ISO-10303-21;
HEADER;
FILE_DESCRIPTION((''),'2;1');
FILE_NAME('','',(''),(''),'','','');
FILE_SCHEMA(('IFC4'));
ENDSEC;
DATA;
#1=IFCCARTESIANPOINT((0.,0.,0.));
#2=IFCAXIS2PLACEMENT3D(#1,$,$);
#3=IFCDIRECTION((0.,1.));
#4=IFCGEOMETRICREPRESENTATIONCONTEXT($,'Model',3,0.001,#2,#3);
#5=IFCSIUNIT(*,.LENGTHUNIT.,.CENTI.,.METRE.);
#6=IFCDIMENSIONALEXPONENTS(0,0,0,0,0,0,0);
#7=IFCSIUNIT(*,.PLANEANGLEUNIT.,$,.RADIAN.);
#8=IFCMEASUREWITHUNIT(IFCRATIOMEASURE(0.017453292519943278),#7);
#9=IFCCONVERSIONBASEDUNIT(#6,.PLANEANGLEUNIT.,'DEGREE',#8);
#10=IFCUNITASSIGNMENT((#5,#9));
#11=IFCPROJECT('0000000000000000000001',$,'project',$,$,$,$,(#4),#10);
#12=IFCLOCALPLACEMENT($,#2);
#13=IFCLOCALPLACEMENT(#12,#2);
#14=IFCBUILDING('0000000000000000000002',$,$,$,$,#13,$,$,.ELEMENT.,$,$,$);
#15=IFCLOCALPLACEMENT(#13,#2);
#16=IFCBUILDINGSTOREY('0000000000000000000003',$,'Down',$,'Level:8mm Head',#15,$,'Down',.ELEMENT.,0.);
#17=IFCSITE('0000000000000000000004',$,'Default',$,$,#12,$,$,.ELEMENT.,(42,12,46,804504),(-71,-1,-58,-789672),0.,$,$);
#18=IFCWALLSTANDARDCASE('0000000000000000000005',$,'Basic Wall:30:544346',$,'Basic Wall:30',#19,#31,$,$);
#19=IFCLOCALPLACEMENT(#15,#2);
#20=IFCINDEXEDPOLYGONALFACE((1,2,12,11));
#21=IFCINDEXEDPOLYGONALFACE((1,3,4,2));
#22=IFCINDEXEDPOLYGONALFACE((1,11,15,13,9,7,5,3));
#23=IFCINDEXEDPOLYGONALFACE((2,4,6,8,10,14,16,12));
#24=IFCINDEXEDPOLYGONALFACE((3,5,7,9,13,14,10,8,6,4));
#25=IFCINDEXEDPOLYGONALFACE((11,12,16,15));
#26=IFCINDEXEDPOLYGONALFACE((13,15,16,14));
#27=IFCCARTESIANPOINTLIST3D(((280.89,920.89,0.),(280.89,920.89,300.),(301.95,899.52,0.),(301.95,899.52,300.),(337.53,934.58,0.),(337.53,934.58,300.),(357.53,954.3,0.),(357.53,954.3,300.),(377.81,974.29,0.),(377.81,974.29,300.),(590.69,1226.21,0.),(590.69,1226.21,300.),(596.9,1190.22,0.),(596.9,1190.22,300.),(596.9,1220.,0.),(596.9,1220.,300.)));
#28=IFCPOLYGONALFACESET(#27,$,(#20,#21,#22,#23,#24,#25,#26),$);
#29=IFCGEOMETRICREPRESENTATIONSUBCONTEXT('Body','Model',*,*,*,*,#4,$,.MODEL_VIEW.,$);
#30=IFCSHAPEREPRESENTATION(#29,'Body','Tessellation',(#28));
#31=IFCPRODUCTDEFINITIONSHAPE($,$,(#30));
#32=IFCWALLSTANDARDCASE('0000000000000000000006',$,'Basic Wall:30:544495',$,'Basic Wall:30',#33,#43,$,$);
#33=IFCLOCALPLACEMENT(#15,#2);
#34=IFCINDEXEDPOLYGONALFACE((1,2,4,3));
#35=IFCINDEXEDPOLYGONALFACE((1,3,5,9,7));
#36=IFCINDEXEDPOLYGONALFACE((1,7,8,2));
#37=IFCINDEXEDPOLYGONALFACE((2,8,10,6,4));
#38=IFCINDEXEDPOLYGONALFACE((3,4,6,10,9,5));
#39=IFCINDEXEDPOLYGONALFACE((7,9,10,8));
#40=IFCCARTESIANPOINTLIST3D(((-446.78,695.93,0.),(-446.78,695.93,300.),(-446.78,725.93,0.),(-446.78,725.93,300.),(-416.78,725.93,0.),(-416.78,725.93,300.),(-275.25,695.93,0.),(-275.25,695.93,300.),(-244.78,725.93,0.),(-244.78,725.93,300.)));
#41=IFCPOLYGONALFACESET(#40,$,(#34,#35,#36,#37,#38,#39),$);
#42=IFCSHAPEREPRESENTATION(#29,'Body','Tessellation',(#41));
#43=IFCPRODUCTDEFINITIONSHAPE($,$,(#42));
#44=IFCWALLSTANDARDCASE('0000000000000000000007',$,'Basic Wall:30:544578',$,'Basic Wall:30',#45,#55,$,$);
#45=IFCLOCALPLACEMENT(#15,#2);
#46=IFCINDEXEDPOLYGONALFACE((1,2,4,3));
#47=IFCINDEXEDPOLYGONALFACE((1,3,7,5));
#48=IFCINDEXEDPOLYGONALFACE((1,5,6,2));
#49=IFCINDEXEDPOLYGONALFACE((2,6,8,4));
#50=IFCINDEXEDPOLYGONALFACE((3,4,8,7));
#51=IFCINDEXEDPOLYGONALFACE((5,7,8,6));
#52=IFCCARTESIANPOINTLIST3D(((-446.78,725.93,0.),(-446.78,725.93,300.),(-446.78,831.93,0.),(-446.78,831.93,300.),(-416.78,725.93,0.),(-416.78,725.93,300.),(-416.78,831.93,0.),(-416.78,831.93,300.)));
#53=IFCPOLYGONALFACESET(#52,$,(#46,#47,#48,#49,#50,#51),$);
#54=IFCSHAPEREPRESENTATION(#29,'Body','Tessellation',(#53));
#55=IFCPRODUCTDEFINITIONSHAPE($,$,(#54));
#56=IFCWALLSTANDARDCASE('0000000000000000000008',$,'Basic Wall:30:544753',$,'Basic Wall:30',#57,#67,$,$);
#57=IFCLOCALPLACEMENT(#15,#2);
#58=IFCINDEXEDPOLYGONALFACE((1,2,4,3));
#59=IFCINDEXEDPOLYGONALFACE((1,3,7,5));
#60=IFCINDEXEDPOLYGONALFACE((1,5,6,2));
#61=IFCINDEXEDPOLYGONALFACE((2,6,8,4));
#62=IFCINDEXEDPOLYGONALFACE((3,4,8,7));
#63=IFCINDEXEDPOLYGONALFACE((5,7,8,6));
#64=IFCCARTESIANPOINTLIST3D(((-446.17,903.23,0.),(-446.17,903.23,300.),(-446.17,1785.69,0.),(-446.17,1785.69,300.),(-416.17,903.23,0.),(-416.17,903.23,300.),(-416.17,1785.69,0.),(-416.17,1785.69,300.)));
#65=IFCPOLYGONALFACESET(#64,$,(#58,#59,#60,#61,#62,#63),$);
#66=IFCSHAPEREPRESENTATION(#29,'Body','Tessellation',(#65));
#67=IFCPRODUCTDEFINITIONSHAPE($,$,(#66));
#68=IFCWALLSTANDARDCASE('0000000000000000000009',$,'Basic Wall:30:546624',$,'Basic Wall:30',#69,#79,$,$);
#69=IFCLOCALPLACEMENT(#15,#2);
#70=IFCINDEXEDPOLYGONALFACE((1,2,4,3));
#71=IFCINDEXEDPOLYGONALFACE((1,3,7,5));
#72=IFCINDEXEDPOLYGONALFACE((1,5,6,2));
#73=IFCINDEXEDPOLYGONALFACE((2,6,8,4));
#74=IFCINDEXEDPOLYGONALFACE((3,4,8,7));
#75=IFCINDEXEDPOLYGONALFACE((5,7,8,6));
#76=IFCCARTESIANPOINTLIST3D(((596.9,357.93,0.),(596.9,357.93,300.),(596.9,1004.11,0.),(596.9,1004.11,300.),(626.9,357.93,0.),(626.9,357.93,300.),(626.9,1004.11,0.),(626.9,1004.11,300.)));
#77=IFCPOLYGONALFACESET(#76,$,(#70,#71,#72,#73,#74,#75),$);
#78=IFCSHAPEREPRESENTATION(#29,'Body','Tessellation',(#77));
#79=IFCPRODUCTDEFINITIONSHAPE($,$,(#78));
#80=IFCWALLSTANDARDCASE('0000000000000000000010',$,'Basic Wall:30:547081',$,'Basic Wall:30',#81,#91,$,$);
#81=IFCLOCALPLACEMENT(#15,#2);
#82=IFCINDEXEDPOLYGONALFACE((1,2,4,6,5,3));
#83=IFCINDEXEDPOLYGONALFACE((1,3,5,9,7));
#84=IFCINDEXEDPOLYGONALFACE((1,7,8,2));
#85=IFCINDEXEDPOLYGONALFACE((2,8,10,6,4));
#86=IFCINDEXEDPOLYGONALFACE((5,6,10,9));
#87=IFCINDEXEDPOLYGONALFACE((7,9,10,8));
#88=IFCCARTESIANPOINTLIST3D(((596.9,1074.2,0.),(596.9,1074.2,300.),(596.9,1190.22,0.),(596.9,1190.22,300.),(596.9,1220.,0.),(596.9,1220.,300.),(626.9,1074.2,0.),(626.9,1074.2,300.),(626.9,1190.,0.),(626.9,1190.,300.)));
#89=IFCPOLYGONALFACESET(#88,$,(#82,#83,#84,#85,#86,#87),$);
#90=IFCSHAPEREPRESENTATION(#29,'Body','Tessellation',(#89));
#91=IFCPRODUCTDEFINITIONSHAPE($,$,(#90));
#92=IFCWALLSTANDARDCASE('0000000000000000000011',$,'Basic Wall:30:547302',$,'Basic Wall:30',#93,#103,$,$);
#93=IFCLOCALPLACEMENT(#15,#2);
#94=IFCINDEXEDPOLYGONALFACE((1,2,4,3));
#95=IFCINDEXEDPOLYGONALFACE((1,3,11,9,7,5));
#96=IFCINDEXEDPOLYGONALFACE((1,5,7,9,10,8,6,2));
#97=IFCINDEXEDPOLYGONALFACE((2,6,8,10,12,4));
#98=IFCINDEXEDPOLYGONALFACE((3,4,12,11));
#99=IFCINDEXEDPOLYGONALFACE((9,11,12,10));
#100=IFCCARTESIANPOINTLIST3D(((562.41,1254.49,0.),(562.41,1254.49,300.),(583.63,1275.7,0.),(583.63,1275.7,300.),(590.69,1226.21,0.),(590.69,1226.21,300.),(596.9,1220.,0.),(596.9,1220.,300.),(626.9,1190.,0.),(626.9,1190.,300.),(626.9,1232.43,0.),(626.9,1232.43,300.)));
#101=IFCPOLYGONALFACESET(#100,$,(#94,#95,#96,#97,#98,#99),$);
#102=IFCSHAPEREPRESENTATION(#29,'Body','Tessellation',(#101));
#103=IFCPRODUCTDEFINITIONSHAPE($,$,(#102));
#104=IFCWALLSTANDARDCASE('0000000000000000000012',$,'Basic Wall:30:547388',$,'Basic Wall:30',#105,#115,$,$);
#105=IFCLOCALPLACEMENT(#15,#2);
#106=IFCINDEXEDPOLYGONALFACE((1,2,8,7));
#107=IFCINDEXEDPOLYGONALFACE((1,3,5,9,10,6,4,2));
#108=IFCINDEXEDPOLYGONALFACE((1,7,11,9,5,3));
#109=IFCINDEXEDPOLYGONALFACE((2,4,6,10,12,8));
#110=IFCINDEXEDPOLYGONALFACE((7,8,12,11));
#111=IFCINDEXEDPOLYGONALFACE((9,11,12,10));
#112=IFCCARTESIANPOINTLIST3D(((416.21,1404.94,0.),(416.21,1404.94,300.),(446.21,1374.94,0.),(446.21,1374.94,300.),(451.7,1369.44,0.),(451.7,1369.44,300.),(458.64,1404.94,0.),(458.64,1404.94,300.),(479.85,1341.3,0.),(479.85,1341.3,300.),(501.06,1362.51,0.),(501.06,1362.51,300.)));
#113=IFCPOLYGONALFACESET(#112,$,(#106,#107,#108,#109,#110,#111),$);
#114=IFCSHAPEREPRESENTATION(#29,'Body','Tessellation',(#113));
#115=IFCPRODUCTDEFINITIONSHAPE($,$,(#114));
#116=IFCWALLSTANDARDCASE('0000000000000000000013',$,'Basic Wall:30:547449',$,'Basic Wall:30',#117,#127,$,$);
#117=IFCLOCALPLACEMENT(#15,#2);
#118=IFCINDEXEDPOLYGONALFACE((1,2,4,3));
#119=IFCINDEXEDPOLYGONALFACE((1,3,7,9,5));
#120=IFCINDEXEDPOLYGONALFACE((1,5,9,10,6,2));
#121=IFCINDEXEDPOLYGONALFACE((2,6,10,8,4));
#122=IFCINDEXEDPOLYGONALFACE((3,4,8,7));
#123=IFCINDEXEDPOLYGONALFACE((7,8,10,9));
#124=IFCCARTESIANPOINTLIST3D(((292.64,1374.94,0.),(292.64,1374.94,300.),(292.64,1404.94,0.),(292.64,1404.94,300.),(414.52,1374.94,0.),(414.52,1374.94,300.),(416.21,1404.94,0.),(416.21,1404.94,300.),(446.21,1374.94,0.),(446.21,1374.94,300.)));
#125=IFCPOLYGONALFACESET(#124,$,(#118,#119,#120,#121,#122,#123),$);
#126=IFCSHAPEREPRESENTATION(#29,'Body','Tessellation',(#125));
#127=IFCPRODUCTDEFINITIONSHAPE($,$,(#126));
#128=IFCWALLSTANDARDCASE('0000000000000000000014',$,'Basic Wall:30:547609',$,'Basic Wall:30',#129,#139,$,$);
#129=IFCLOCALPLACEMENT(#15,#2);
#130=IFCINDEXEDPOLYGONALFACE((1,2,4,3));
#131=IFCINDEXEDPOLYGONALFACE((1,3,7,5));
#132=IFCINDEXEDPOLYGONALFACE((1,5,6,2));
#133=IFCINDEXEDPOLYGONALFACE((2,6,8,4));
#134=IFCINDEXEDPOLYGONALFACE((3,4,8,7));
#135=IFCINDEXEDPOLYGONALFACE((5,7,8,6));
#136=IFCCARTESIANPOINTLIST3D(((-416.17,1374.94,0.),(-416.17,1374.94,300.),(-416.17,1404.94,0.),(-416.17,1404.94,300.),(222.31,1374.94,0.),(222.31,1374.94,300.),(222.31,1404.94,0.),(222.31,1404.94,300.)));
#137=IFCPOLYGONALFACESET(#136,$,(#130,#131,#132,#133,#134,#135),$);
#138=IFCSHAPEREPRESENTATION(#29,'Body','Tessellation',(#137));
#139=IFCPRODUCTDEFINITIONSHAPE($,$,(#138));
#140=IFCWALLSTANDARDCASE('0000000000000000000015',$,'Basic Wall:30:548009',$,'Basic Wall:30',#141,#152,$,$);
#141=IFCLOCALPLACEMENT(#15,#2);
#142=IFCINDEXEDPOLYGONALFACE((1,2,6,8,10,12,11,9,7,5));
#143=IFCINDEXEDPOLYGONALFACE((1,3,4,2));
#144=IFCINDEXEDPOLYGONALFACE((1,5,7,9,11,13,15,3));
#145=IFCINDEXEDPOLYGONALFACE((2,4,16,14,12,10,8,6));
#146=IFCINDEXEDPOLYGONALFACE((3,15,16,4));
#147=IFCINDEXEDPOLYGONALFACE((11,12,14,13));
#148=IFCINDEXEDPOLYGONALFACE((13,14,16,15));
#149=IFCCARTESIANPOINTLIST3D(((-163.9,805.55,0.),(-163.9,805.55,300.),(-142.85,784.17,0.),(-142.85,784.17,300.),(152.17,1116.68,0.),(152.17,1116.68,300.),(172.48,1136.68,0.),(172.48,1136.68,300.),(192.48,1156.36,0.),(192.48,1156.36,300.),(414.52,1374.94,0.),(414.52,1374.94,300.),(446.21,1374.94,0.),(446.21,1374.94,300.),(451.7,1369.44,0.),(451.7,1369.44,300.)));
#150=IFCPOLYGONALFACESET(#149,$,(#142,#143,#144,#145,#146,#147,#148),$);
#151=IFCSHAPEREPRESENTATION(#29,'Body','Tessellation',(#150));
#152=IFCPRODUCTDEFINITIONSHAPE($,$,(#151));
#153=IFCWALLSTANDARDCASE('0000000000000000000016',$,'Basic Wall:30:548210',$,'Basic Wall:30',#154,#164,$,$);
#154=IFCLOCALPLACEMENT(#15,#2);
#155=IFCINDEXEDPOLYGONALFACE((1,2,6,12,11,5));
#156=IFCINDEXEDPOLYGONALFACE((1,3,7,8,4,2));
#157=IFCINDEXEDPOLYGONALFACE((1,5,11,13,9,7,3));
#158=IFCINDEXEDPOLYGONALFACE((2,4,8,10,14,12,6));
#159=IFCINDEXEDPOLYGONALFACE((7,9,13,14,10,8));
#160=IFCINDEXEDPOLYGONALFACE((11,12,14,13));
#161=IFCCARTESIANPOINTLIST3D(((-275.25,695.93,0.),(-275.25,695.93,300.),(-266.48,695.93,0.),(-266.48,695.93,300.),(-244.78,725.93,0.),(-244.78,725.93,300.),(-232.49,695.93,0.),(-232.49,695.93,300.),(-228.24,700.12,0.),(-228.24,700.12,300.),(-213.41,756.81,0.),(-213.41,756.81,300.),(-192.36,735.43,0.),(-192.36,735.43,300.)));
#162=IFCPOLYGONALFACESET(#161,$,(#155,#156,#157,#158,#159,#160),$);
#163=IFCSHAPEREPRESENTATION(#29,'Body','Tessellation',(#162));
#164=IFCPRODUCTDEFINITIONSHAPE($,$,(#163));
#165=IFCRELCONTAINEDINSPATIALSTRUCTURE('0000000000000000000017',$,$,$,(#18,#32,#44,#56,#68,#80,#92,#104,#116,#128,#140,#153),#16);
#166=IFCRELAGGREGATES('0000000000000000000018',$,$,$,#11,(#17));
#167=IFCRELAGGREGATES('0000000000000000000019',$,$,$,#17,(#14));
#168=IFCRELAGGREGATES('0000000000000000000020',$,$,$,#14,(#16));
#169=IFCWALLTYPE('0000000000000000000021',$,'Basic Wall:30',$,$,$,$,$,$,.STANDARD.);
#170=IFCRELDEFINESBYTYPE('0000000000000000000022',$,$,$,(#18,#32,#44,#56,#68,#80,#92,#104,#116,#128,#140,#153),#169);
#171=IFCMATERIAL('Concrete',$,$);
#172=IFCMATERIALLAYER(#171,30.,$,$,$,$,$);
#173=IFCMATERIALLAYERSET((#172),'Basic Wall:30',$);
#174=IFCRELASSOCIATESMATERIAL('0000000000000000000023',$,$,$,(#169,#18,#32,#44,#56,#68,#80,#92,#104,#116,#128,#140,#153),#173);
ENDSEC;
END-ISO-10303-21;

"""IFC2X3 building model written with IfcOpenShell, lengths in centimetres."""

from ifc_helpers import new_model, entity, si_unit, converted_unit, direction, frame, frame_2d, origin, place, context, subcontext, project, spatial, polyline, rectangle, outline, extrude, material, layer, layer_set, layer_usage, type_object, element, save


model = new_model("IFC2X3")

# Units and contexts
model_context = context("Model", 3, precision=0.001, world=origin(), true_north=direction((0.0, 1.0)))
body_context = subcontext(model_context, "Body", "Model", "MODEL_VIEW")
ifc_project = project(units=[si_unit("LENGTHUNIT", "METRE", prefix="CENTI"), converted_unit("PLANEANGLEUNIT", "DEGREE", entity("IfcRatioMeasure", 0.017453292519943278), si_unit("PLANEANGLEUNIT", "RADIAN"), dimensions=[0, 0, 0, 0, 0, 0, 0])], contexts=[model_context])

# Site, building, storey
site_placement = place(None, origin())
site = spatial("IfcSite", under=ifc_project, at=site_placement, Name="Default", CompositionType="ELEMENT", RefLatitude=(42, 12, 46, 804504), RefLongitude=(-71, -1, -58, -789672), RefElevation=0.0)
building_placement = place(site_placement, origin())
building = spatial("IfcBuilding", under=site, at=building_placement, CompositionType="ELEMENT")
storey_placement = place(building_placement, origin())
storey = spatial("IfcBuildingStorey", under=building, at=storey_placement, Name="Down", ObjectType="Level:8mm Head", LongName="Down", CompositionType="ELEMENT", Elevation=0.0)

# Walls
ifc_material = material(Name="Concrete")
ifc_layer_1 = layer(ifc_material, 30.0)
ifc_layer_set_1 = layer_set([ifc_layer_1], Name="Basic Wall:30")
wall_type_1 = type_object("IfcWallType", Name="Basic Wall:30", PredefinedType="STANDARD", material=ifc_layer_set_1)
ifc_layer_usage_1 = layer_usage(ifc_layer_set_1, "AXIS2", "POSITIVE", -15.0)
wall_1_placement = place(storey_placement, frame((291.42, 910.2, 0.0), z_axis=(0.0, 0.0, 1.0), x_axis=(0.712224, 0.701952, 0.0)))
element("IfcWallStandardCase", 1, at=wall_1_placement, inside=storey, type_object=wall_type_1, material=ifc_layer_usage_1, Name="Basic Wall:30:544346", ObjectType="Basic Wall:30", context=body_context, shape_type="SweptSolid", body=[
    extrude(outline(polyline([(414.13, -15.0), (435.03, 6.21), (434.97, 15.0), (0.0, 15.0), (0.0, -15.0), (49.96, -15.0), (78.04, -15.0), (106.51, -15.0), (414.13, -15.0)])), origin(), (0.0, 0.0, 1.0), 300.0),
])
ifc_layer_usage_2 = layer_usage(ifc_layer_set_1, "AXIS2", "POSITIVE", -15.0)
wall_2_placement = place(storey_placement, frame((-244.78, 710.93, 0.0), z_axis=(0.0, 0.0, 1.0), x_axis=(-1.0, 0.0, 0.0)))
element("IfcWallStandardCase", 2, at=wall_2_placement, inside=storey, type_object=wall_type_1, material=ifc_layer_usage_2, Name="Basic Wall:30:544495", ObjectType="Basic Wall:30", context=body_context, shape_type="SweptSolid", body=[
    extrude(outline(polyline([(202.0, -15.0), (202.0, 15.0), (30.48, 15.0), (0.0, -15.0), (172.0, -15.0), (202.0, -15.0)])), origin(), (0.0, 0.0, 1.0), 300.0),
])
ifc_layer_usage_3 = layer_usage(ifc_layer_set_1, "AXIS2", "NEGATIVE", 15.0)
wall_3_placement = place(storey_placement, frame((-431.78, 725.93, 0.0), z_axis=(0.0, 0.0, 1.0), x_axis=(0.0, 1.0, 0.0)))
element("IfcWallStandardCase", 3, at=wall_3_placement, inside=storey, type_object=wall_type_1, material=ifc_layer_usage_3, Name="Basic Wall:30:544578", ObjectType="Basic Wall:30", context=body_context, shape_type="SweptSolid", body=[
    extrude(rectangle(XDim=106.0, YDim=30.0, at=frame_2d((53.0, 0.0), x_axis=(-1.0, 0.0))), origin(), (0.0, 0.0, 1.0), 300.0),
])
ifc_layer_usage_4 = layer_usage(ifc_layer_set_1, "AXIS2", "NEGATIVE", 15.0)
wall_4_placement = place(storey_placement, frame((-431.17, 903.23, 0.0), z_axis=(0.0, 0.0, 1.0), x_axis=(0.0, 1.0, 0.0)))
element("IfcWallStandardCase", 4, at=wall_4_placement, inside=storey, type_object=wall_type_1, material=ifc_layer_usage_4, Name="Basic Wall:30:544753", ObjectType="Basic Wall:30", context=body_context, shape_type="SweptSolid", body=[
    extrude(rectangle(XDim=882.46, YDim=30.0, at=frame_2d((441.23, 0.0), x_axis=(-1.0, 0.0))), origin(), (0.0, 0.0, 1.0), 300.0),
])
ifc_layer_usage_5 = layer_usage(ifc_layer_set_1, "AXIS2", "POSITIVE", -15.0)
wall_5_placement = place(storey_placement, frame((611.9, 1004.11, 0.0), z_axis=(0.0, 0.0, 1.0), x_axis=(0.0, -1.0, 0.0)))
element("IfcWallStandardCase", 5, at=wall_5_placement, inside=storey, type_object=wall_type_1, material=ifc_layer_usage_5, Name="Basic Wall:30:546624", ObjectType="Basic Wall:30", context=body_context, shape_type="SweptSolid", body=[
    extrude(rectangle(XDim=646.18, YDim=30.0, at=frame_2d((323.09, 0.0), x_axis=(-1.0, 0.0))), origin(), (0.0, 0.0, 1.0), 300.0),
])
ifc_layer_usage_6 = layer_usage(ifc_layer_set_1, "AXIS2", "POSITIVE", -15.0)
wall_6_placement = place(storey_placement, frame((611.9, 1074.2, 0.0), z_axis=(0.0, 0.0, 1.0), x_axis=(0.0, 1.0, 0.0)))
element("IfcWallStandardCase", 6, at=wall_6_placement, inside=storey, type_object=wall_type_1, material=ifc_layer_usage_6, Name="Basic Wall:30:547081", ObjectType="Basic Wall:30", context=body_context, shape_type="SweptSolid", body=[
    extrude(outline(polyline([(115.8, -15.0), (145.8, 15.0), (116.02, 15.0), (0.0, 15.0), (0.0, -15.0), (115.8, -15.0)])), origin(), (0.0, 0.0, 1.0), 300.0),
])
ifc_layer_usage_7 = layer_usage(ifc_layer_set_1, "AXIS2", "POSITIVE", -15.0)
wall_7_placement = place(storey_placement, frame((637.51, 1200.61, 0.0), z_axis=(0.0, 0.0, 1.0), x_axis=(-0.707107, 0.707107, 0.0)))
element("IfcWallStandardCase", 7, at=wall_7_placement, inside=storey, type_object=wall_type_1, material=ifc_layer_usage_7, Name="Basic Wall:30:547302", ObjectType="Basic Wall:30", context=body_context, shape_type="SweptSolid", body=[
    extrude(outline(polyline([(91.2, -15.0), (91.2, 15.0), (51.22, 15.0), (42.43, 15.0), (0.0, 15.0), (30.0, -15.0), (91.2, -15.0)])), origin(), (0.0, 0.0, 1.0), 300.0),
])
ifc_layer_usage_8 = layer_usage(ifc_layer_set_1, "AXIS2", "POSITIVE", -15.0)
wall_8_placement = place(storey_placement, frame((490.46, 1351.9, 0.0), z_axis=(0.0, 0.0, 1.0), x_axis=(-0.707107, 0.707107, 0.0)))
element("IfcWallStandardCase", 8, at=wall_8_placement, inside=storey, type_object=wall_type_1, material=ifc_layer_usage_8, Name="Basic Wall:30:547388", ObjectType="Basic Wall:30", context=body_context, shape_type="SweptSolid", body=[
    extrude(outline(polyline([(60.0, -15.0), (90.0, 15.0), (47.57, 15.0), (39.8, 15.0), (0.0, 15.0), (0.0, -15.0), (60.0, -15.0)])), origin(), (0.0, 0.0, 1.0), 300.0),
])
ifc_layer_usage_9 = layer_usage(ifc_layer_set_1, "AXIS2", "POSITIVE", -15.0)
wall_9_placement = place(storey_placement, frame((446.21, 1389.94, 0.0), z_axis=(0.0, 0.0, 1.0), x_axis=(-1.0, 0.0, 0.0)))
element("IfcWallStandardCase", 9, at=wall_9_placement, inside=storey, type_object=wall_type_1, material=ifc_layer_usage_9, Name="Basic Wall:30:547449", ObjectType="Basic Wall:30", context=body_context, shape_type="SweptSolid", body=[
    extrude(outline(polyline([(153.57, -15.0), (153.57, 15.0), (31.69, 15.0), (0.0, 15.0), (30.0, -15.0), (153.57, -15.0)])), origin(), (0.0, 0.0, 1.0), 300.0),
])
ifc_layer_usage_10 = layer_usage(ifc_layer_set_1, "AXIS2", "POSITIVE", -15.0)
wall_10_placement = place(storey_placement, frame((222.31, 1389.94, 0.0), z_axis=(0.0, 0.0, 1.0), x_axis=(-1.0, 0.0, 0.0)))
element("IfcWallStandardCase", 10, at=wall_10_placement, inside=storey, type_object=wall_type_1, material=ifc_layer_usage_10, Name="Basic Wall:30:547609", ObjectType="Basic Wall:30", context=body_context, shape_type="SweptSolid", body=[
    extrude(rectangle(XDim=638.48, YDim=30.0, at=frame_2d((319.24, 0.0), x_axis=(-1.0, 0.0))), origin(), (0.0, 0.0, 1.0), 300.0),
])
ifc_layer_usage_11 = layer_usage(ifc_layer_set_1, "AXIS2", "NEGATIVE", 15.0)
wall_11_placement = place(storey_placement, frame((441.18, 1380.13, 0.0), z_axis=(0.0, 0.0, 1.0), x_axis=(-0.712648, -0.701522, 0.0)))
element("IfcWallStandardCase", 11, at=wall_11_placement, inside=storey, type_object=wall_type_1, material=ifc_layer_usage_11, Name="Basic Wall:30:548009", ObjectType="Basic Wall:30", context=body_context, shape_type="SweptSolid", body=[
    extrude(outline(polyline([(834.29, -15.0), (834.29, 15.0), (0.0, 15.0), (0.06, 7.23), (22.64, -15.0), (334.21, -15.0), (362.28, -15.0), (390.79, -15.0), (834.29, -15.0)])), origin(), (0.0, 0.0, 1.0), 300.0),
])
ifc_layer_usage_12 = layer_usage(ifc_layer_set_1, "AXIS2", "NEGATIVE", 15.0)
wall_12_placement = place(storey_placement, frame((-202.88, 746.12, 0.0), z_axis=(0.0, 0.0, 1.0), x_axis=(-0.712648, -0.701522, 0.0)))
element("IfcWallStandardCase", 12, at=wall_12_placement, inside=storey, type_object=wall_type_1, material=ifc_layer_usage_12, Name="Basic Wall:30:548210", ObjectType="Basic Wall:30", context=body_context, shape_type="SweptSolid", body=[
    extrude(outline(polyline([(86.78, -15.0), (80.53, -8.85), (56.31, 15.0), (50.35, 15.0), (0.0, 15.0), (0.0, -15.0), (44.02, -15.0), (86.78, -15.0)])), origin(), (0.0, 0.0, 1.0), 300.0),
])

save(model, "model.ifc")
